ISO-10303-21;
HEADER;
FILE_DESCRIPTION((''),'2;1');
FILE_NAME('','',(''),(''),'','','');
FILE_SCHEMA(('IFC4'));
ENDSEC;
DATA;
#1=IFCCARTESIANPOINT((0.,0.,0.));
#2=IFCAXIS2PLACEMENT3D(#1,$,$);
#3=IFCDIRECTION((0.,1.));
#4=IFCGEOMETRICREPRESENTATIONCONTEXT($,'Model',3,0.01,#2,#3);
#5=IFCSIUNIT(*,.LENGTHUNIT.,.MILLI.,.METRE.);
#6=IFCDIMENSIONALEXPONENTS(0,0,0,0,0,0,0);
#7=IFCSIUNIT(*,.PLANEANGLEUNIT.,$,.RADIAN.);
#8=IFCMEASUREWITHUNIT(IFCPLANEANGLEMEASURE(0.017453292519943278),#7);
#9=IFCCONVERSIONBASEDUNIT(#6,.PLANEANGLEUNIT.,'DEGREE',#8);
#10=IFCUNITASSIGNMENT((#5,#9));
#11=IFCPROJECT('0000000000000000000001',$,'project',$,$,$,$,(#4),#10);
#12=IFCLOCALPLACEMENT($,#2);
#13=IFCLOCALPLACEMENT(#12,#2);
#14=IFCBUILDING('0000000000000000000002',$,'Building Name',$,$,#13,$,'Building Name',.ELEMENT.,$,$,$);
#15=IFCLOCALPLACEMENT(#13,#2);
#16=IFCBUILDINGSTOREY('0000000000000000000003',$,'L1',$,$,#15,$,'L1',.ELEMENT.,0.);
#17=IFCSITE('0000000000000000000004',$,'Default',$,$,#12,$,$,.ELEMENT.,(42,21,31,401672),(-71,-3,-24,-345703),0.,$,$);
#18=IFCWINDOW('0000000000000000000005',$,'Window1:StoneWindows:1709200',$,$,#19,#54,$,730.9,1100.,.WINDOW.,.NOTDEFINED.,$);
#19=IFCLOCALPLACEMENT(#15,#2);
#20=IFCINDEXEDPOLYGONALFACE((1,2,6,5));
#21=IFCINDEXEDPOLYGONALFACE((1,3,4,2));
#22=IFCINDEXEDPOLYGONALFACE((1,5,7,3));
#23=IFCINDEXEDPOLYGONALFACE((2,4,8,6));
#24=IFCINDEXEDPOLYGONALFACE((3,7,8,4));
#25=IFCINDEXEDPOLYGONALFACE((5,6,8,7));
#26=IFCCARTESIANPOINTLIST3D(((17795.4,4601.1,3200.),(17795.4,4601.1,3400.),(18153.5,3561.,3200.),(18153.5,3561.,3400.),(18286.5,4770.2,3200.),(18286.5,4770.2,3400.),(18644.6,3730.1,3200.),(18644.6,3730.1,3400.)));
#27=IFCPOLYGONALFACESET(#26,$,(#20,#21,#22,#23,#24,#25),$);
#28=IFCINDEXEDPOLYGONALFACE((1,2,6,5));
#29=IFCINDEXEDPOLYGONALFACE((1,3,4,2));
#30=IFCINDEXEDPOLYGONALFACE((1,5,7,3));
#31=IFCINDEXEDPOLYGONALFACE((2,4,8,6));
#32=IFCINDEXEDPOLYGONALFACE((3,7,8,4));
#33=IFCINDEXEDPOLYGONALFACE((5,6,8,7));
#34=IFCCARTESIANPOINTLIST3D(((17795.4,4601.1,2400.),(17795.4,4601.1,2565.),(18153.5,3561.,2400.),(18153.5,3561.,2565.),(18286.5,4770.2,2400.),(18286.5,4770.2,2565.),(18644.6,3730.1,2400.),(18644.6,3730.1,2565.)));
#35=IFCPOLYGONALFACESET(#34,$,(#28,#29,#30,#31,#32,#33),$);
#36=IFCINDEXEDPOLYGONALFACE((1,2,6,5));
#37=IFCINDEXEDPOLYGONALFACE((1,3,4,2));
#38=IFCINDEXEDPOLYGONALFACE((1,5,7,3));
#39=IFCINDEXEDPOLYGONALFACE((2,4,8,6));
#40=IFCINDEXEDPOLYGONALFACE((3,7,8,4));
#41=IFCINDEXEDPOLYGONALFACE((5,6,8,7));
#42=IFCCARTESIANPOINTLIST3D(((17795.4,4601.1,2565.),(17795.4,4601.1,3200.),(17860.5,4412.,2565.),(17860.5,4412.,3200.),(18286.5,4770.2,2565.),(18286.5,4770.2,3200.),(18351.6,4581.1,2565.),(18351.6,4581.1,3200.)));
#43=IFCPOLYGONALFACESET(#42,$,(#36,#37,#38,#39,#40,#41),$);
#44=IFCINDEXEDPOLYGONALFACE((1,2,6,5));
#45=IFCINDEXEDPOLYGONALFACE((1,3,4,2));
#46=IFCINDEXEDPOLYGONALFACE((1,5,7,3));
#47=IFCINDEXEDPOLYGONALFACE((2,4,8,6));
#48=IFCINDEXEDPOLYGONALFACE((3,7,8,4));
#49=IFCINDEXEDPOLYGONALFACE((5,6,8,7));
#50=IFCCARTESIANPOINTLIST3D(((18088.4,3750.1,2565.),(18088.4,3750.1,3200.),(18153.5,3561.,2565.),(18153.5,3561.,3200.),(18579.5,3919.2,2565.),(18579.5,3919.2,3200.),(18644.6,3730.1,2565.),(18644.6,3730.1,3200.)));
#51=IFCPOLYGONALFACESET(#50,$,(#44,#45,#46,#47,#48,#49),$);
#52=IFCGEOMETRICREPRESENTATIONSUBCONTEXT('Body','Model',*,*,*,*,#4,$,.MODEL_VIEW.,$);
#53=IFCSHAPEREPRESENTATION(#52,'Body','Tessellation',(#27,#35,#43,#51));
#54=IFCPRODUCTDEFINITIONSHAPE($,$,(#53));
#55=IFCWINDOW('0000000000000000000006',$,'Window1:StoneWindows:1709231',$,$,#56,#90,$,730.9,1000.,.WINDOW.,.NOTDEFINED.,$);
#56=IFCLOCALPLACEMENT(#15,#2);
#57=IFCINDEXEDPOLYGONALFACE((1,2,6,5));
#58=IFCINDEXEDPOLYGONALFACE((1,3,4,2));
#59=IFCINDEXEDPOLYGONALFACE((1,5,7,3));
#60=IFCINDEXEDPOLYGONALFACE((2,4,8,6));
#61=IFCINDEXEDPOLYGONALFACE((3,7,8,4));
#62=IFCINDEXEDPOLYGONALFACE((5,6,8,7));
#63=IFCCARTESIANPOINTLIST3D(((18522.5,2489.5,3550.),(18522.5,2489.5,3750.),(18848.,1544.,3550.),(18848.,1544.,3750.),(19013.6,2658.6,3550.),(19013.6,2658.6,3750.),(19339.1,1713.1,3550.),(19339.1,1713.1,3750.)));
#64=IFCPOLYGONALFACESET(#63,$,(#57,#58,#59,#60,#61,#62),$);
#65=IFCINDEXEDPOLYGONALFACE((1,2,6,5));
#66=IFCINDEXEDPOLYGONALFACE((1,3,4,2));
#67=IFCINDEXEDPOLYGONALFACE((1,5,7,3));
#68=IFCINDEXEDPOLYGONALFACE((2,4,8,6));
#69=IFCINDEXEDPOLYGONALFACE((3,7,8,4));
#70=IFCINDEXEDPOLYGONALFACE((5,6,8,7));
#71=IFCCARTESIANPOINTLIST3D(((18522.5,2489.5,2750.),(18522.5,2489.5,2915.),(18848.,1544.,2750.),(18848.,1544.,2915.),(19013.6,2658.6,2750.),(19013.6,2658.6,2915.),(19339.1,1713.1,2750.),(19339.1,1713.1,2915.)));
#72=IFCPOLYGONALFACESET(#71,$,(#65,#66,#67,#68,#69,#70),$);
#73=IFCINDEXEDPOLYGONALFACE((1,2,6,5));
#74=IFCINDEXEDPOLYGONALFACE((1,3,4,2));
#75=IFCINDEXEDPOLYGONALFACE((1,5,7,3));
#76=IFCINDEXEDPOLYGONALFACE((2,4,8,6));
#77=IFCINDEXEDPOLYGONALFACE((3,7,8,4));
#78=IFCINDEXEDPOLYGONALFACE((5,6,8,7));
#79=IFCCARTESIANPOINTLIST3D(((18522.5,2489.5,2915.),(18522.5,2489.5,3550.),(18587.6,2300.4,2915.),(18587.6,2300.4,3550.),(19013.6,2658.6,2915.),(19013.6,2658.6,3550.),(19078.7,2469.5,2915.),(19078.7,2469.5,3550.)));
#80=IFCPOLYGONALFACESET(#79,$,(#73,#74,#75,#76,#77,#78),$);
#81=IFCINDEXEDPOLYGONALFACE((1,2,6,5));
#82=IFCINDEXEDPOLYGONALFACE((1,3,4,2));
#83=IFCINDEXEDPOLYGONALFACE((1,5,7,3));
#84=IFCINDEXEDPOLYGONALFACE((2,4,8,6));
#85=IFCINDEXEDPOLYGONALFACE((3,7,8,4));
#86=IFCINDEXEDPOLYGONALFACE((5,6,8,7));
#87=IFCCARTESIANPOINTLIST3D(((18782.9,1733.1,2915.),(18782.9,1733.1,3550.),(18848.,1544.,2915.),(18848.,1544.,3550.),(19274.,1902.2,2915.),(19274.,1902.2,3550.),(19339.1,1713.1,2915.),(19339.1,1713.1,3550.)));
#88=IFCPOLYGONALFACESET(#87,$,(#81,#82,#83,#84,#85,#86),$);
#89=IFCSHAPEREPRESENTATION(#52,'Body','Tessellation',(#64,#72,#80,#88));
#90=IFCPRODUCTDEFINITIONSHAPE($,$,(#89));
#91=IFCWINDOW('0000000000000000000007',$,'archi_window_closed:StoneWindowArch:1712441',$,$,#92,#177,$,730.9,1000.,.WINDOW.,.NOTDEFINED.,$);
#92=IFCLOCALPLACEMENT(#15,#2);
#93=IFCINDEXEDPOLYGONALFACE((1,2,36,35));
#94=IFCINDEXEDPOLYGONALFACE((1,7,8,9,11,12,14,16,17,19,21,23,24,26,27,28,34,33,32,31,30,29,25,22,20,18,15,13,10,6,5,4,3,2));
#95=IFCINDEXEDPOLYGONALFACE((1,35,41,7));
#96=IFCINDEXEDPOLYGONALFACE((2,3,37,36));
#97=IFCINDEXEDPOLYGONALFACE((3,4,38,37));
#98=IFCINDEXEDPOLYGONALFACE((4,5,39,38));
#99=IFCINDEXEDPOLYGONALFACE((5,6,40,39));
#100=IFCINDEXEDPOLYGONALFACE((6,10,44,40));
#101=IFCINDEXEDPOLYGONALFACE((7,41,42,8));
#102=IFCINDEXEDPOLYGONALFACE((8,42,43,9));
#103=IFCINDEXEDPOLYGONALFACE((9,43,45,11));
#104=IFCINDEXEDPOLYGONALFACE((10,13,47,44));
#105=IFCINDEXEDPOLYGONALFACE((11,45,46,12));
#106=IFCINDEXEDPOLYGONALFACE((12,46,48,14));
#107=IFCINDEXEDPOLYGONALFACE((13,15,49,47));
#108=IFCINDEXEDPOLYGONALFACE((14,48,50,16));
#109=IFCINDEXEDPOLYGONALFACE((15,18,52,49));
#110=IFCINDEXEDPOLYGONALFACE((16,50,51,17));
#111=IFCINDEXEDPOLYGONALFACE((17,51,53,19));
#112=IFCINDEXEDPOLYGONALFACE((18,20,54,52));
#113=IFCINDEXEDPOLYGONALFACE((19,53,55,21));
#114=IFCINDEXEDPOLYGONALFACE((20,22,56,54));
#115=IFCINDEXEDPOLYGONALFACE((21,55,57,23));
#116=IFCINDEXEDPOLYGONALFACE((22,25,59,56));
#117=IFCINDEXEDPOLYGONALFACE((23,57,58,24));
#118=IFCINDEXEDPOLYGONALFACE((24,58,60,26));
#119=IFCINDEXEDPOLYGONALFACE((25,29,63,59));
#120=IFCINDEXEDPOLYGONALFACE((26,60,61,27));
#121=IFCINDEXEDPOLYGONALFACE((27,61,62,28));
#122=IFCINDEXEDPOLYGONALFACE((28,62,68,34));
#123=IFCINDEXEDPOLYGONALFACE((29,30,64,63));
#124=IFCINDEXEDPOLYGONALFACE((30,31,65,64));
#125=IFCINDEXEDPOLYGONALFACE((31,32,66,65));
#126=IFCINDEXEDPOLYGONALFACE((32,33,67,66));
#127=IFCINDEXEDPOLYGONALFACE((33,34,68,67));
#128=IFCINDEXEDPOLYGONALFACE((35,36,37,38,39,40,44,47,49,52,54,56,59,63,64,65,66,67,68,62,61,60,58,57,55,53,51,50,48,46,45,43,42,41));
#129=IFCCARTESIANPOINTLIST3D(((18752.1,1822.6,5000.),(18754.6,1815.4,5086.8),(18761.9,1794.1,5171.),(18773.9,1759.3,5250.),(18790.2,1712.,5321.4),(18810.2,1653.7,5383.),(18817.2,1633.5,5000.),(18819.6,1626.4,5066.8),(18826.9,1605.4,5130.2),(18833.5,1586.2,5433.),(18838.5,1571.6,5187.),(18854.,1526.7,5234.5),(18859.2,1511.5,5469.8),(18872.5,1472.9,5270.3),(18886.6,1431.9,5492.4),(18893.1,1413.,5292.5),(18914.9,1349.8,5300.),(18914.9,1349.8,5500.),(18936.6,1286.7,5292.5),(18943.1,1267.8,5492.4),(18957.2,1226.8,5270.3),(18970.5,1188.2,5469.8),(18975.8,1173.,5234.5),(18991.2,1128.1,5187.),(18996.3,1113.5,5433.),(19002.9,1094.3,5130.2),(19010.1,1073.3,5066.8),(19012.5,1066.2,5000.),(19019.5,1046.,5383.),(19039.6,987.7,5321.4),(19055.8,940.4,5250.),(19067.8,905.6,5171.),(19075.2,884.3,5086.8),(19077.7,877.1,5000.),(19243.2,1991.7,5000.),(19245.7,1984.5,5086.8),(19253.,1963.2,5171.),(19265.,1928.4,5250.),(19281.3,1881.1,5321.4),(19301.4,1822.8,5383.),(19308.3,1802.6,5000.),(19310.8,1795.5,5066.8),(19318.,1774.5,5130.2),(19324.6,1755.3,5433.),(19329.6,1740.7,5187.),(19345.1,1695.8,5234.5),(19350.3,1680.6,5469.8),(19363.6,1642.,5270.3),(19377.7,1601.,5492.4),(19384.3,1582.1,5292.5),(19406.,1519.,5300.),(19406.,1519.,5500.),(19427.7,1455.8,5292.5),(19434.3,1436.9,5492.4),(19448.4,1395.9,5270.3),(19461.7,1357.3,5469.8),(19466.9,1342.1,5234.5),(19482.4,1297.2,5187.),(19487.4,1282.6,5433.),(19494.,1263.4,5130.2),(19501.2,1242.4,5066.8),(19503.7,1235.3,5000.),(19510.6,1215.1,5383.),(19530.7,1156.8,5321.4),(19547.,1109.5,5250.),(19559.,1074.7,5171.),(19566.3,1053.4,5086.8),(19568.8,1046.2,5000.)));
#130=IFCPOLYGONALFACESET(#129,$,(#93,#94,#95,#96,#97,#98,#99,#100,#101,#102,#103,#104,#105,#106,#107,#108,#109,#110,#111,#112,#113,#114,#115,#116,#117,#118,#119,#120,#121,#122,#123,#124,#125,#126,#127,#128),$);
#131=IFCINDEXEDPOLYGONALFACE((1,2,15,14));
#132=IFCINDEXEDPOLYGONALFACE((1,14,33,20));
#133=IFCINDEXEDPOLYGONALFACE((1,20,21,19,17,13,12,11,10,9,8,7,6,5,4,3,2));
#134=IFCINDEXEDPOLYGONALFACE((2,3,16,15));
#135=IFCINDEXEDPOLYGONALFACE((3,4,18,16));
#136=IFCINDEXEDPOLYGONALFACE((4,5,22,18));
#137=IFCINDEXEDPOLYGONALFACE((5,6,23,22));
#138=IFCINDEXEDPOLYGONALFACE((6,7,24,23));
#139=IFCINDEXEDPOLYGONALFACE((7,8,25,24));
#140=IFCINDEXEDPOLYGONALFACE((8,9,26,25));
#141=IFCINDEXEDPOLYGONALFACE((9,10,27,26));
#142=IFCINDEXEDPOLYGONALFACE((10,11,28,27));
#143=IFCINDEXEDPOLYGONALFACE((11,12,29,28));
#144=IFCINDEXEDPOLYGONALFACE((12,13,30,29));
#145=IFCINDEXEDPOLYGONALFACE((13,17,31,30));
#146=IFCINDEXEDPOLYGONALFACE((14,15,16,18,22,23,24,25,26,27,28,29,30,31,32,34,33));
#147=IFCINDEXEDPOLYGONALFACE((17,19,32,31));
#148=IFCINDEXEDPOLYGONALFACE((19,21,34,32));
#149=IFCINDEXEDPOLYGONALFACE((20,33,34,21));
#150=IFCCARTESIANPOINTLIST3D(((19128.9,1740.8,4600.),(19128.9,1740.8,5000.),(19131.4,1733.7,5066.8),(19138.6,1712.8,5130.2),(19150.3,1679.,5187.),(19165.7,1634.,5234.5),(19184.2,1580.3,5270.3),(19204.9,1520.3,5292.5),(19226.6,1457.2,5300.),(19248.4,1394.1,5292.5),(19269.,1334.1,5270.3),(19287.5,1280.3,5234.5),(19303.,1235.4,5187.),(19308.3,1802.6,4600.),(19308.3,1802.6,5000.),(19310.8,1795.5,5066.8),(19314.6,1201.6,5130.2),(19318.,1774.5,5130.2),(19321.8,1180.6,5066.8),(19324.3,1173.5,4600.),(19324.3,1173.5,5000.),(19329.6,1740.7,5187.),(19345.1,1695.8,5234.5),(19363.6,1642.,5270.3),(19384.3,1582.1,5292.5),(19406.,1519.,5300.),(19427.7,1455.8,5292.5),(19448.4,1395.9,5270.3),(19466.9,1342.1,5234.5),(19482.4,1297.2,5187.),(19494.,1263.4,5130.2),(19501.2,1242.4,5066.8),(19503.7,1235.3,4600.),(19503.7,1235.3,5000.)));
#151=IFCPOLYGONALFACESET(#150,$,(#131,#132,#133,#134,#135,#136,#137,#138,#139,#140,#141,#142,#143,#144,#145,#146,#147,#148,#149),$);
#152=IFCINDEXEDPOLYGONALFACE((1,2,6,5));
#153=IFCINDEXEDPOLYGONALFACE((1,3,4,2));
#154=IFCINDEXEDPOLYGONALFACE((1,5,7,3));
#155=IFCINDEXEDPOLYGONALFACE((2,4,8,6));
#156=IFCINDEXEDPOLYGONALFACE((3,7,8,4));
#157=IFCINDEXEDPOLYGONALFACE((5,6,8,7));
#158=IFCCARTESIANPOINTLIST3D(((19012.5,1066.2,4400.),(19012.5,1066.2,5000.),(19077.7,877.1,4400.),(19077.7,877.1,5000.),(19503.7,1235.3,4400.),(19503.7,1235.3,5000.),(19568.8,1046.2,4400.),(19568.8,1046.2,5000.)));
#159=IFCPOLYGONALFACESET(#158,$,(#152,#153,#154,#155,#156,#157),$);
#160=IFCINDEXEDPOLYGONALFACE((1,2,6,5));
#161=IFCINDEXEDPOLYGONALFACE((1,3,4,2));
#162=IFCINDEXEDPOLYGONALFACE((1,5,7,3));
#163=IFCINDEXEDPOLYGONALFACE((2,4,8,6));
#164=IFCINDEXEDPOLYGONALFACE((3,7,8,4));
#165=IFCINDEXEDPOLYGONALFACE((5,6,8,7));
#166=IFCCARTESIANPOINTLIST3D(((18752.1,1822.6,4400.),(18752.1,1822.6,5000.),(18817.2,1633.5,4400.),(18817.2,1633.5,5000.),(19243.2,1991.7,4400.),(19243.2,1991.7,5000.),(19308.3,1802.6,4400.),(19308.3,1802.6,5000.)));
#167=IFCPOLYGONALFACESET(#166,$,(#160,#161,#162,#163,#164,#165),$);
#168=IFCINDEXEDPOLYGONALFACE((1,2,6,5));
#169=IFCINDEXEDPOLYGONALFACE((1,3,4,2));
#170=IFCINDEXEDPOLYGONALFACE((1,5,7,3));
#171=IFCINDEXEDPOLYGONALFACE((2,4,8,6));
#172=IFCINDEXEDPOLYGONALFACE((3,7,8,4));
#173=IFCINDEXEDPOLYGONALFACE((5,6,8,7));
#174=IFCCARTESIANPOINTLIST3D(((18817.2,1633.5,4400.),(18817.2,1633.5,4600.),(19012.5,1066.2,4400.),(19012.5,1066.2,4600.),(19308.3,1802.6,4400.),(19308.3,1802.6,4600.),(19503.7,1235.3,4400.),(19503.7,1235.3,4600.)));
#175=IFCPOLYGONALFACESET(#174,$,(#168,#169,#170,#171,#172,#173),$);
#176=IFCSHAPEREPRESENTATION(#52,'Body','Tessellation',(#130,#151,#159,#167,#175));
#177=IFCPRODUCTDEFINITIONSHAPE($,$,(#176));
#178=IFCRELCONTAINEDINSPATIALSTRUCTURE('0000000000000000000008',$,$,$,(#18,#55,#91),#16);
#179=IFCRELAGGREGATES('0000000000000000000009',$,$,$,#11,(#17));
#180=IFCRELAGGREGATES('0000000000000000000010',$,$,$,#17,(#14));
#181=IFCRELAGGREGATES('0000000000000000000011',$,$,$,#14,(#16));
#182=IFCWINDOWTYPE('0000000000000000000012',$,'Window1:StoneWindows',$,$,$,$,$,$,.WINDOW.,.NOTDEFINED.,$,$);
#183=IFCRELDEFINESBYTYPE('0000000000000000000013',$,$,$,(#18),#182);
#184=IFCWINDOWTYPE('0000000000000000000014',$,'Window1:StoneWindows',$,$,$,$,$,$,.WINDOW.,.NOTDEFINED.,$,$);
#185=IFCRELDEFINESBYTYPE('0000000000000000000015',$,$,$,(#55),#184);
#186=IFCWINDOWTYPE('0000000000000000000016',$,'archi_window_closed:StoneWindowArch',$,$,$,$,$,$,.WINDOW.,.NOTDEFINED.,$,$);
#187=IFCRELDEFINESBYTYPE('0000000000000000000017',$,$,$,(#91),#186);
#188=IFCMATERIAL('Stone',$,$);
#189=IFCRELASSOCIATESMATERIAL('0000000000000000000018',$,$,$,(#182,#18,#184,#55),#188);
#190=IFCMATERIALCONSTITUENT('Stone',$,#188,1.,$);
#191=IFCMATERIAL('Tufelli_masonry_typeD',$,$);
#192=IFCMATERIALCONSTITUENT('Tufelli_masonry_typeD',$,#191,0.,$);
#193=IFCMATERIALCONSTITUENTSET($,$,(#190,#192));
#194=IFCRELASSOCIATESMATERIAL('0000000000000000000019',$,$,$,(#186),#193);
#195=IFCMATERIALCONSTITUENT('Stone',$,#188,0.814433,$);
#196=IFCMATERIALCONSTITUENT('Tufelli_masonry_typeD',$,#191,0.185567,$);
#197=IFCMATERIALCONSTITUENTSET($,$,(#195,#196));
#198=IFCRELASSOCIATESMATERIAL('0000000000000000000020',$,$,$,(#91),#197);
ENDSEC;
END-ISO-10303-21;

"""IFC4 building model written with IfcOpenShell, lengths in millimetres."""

from ifc_helpers import new_model, entity, si_unit, converted_unit, direction, frame, origin, place, context, subcontext, project, spatial, line, arc, indexed_curve, outline, extrude, source, transform, mapped, material, constituent, constituent_set, type_object, type_shapes, element, save


model = new_model("IFC4")

# Units and contexts
model_context = context("Model", 3, precision=0.01, world=origin(), true_north=direction((0.0, 1.0)))
body_context = subcontext(model_context, "Body", "Model", "MODEL_VIEW")
ifc_project = project(units=[si_unit("LENGTHUNIT", "METRE", prefix="MILLI"), converted_unit("PLANEANGLEUNIT", "DEGREE", entity("IfcPlaneAngleMeasure", 0.017453292519943278), si_unit("PLANEANGLEUNIT", "RADIAN"), dimensions=[0, 0, 0, 0, 0, 0, 0])], contexts=[model_context])

# Site, building, storey
site_placement = place(None, origin())
site = spatial("IfcSite", under=ifc_project, at=site_placement, Name="Default", CompositionType="ELEMENT", RefLatitude=(42, 21, 31, 401672), RefLongitude=(-71, -3, -24, -345703), RefElevation=0.0)
building_placement = place(site_placement, origin())
building = spatial("IfcBuilding", under=site, at=building_placement, Name="Building Name", LongName="Building Name", CompositionType="ELEMENT")
storey_placement = place(building_placement, origin())
storey = spatial("IfcBuildingStorey", under=building, at=storey_placement, Name="L1", LongName="L1", CompositionType="ELEMENT", Elevation=0.0)

# Shared definitions
ifc_material_1 = material(Name="Tufelli_masonry_typeD")

# Shared definitions
ifc_material_2 = material(Name="Stone")

# Windows
window_type_1 = type_object("IfcWindowType", Name="Window1:StoneWindows", PartitioningType="NOTDEFINED", PredefinedType="WINDOW", material=ifc_material_2)
shared_shape_1 = source(origin(), body_context, "Body", "SweptSolid", [
    extrude(outline(indexed_curve([(-259.7, -550.0), (259.7, -550.0), (259.7, 550.0), (-259.7, 550.0), (-259.7, -550.0)], self_intersect=False)), frame((0.0, 0.0, 1600.0), z_axis=(0.0, 0.0, 1.0), x_axis=(0.0, 1.0, 0.0)), (0.0, 0.0, 1.0), 200.0),
    extrude(outline(indexed_curve([(-259.7, -550.0), (259.7, -550.0), (259.7, 550.0), (-259.7, 550.0), (-259.7, -550.0)], self_intersect=False)), frame((0.0, 0.0, 800.0), z_axis=(0.0, 0.0, 1.0), x_axis=(0.0, 1.0, 0.0)), (0.0, 0.0, 1.0), 165.0),
    extrude(outline(indexed_curve([(-259.7, -100.0), (259.7, -100.0), (259.7, 100.0), (-259.7, 100.0), (-259.7, -100.0)], self_intersect=False)), frame((-450.0, 0.0, 965.0), z_axis=(0.0, 0.0, 1.0), x_axis=(0.0, 1.0, 0.0)), (0.0, 0.0, 1.0), 635.0),
    extrude(outline(indexed_curve([(-259.7, -100.0), (259.7, -100.0), (259.7, 100.0), (-259.7, 100.0), (-259.7, -100.0)], self_intersect=False)), frame((450.0, 0.0, 965.0), z_axis=(0.0, 0.0, 1.0), x_axis=(0.0, 1.0, 0.0)), (0.0, 0.0, 1.0), 635.0),
])
type_shapes(window_type_1, [shared_shape_1])
window_1_placement = place(storey_placement, frame((18220.0, 4165.6, 1600.0), z_axis=(0.0, 0.0, 1.0), x_axis=(0.325568, -0.945519, 0.0)))
element("IfcWindow", 1, at=window_1_placement, inside=storey, type_object=window_type_1, material=ifc_material_2, Name="Window1:StoneWindows:1709200", OverallHeight=730.9, OverallWidth=1100.0, PartitioningType="NOTDEFINED", PredefinedType="WINDOW", context=body_context, shape_type="MappedRepresentation", body=[
    mapped(shared_shape_1, transform((0.0, 0.0, 0.0), scale=1.0)),
])
window_type_2 = type_object("IfcWindowType", Name="Window1:StoneWindows", PartitioningType="NOTDEFINED", PredefinedType="WINDOW", material=ifc_material_2)
shared_shape_2 = source(origin(), body_context, "Body", "SweptSolid", [
    extrude(outline(indexed_curve([(-259.7, -500.0), (259.7, -500.0), (259.7, 500.0), (-259.7, 500.0), (-259.7, -500.0)], self_intersect=False)), frame((0.0, 0.0, 1600.0), z_axis=(0.0, 0.0, 1.0), x_axis=(0.0, 1.0, 0.0)), (0.0, 0.0, 1.0), 200.0),
    extrude(outline(indexed_curve([(-259.7, -500.0), (259.7, -500.0), (259.7, 500.0), (-259.7, 500.0), (-259.7, -500.0)], self_intersect=False)), frame((0.0, 0.0, 800.0), z_axis=(0.0, 0.0, 1.0), x_axis=(0.0, 1.0, 0.0)), (0.0, 0.0, 1.0), 165.0),
    extrude(outline(indexed_curve([(-259.7, -100.0), (259.7, -100.0), (259.7, 100.0), (-259.7, 100.0), (-259.7, -100.0)], self_intersect=False)), frame((-400.0, 0.0, 965.0), z_axis=(0.0, 0.0, 1.0), x_axis=(0.0, 1.0, 0.0)), (0.0, 0.0, 1.0), 635.0),
    extrude(outline(indexed_curve([(-259.7, -100.0), (259.7, -100.0), (259.7, 100.0), (-259.7, 100.0), (-259.7, -100.0)], self_intersect=False)), frame((400.0, 0.0, 965.0), z_axis=(0.0, 0.0, 1.0), x_axis=(0.0, 1.0, 0.0)), (0.0, 0.0, 1.0), 635.0),
])
type_shapes(window_type_2, [shared_shape_2])
window_2_placement = place(storey_placement, frame((18930.8, 2101.3, 1950.0), z_axis=(0.0, 0.0, 1.0), x_axis=(0.325568, -0.945519, 0.0)))
element("IfcWindow", 2, at=window_2_placement, inside=storey, type_object=window_type_2, material=ifc_material_2, Name="Window1:StoneWindows:1709231", OverallHeight=730.9, OverallWidth=1000.0, PartitioningType="NOTDEFINED", PredefinedType="WINDOW", context=body_context, shape_type="MappedRepresentation", body=[
    mapped(shared_shape_2, transform((0.0, 0.0, 0.0), scale=1.0)),
])
ifc_constituent_1 = constituent(ifc_material_2, Name="Stone", fraction=0.814433)
ifc_constituent_2 = constituent(ifc_material_1, Name="Tufelli_masonry_typeD", fraction=0.185567)
ifc_constituent_set_1 = constituent_set(constituents=[ifc_constituent_1, ifc_constituent_2])
ifc_constituent_3 = constituent(ifc_material_2, Name="Stone", fraction=1.0)
ifc_constituent_4 = constituent(ifc_material_1, Name="Tufelli_masonry_typeD", fraction=0.0)
ifc_constituent_set_2 = constituent_set(constituents=[ifc_constituent_3, ifc_constituent_4])
window_type_3 = type_object("IfcWindowType", Name="archi_window_closed:StoneWindowArch", PartitioningType="NOTDEFINED", PredefinedType="WINDOW", material=ifc_constituent_set_2)
shared_shape_3 = source(origin(), body_context, "Body", "SweptSolid", [
    extrude(outline(indexed_curve([(300.0, 0.0), (500.0, 0.0), (0.0, 500.0), (-500.0, 0.0), (-300.0, 0.0), (0.0, 300.0)], segments=[line(1, 2), arc(2, 3, 4), line(4, 5), arc(5, 6, 1)], self_intersect=False)), frame((0.0, -259.7, 1400.0), z_axis=(0.0, -1.0, 0.0), x_axis=(1.0, 0.0, 0.0)), (0.0, 0.0, -1.0), 519.4),
    extrude(outline(indexed_curve([(-200.0, -300.0), (200.0, -300.0), (200.0, 300.0), (-200.0, 300.0), (-500.0, 0.0)], segments=[line(1, 2, 3, 4), arc(4, 5, 1)], self_intersect=False)), frame((0.0, 70.0, 1200.0), z_axis=(0.0, 1.0, 0.0), x_axis=(0.0, 0.0, -1.0)), (0.0, 0.0, 1.0), 189.7),
    extrude(outline(indexed_curve([(-259.7, -100.0), (259.7, -100.0), (259.7, 100.0), (-259.7, 100.0), (-259.7, -100.0)], self_intersect=False)), frame((400.0, 0.0, 800.0), z_axis=(0.0, 0.0, 1.0), x_axis=(0.0, 1.0, 0.0)), (0.0, 0.0, 1.0), 600.0),
    extrude(outline(indexed_curve([(-259.7, -100.0), (259.7, -100.0), (259.7, 100.0), (-259.7, 100.0), (-259.7, -100.0)], self_intersect=False)), frame((-400.0, 0.0, 800.0), z_axis=(0.0, 0.0, 1.0), x_axis=(0.0, 1.0, 0.0)), (0.0, 0.0, 1.0), 600.0),
    extrude(outline(indexed_curve([(-259.7, -300.0), (259.7, -300.0), (259.7, 300.0), (-259.7, 300.0), (-259.7, -300.0)], self_intersect=False)), frame((0.0, 0.0, 800.0), z_axis=(0.0, 0.0, 1.0), x_axis=(0.0, 1.0, 0.0)), (0.0, 0.0, 1.0), 200.0),
])
type_shapes(window_type_3, [shared_shape_3])
window_3_placement = place(storey_placement, frame((19160.4, 1434.4, 3600.0), z_axis=(0.0, 0.0, 1.0), x_axis=(0.325568, -0.945519, 0.0)))
element("IfcWindow", 3, at=window_3_placement, inside=storey, type_object=window_type_3, material=ifc_constituent_set_1, Name="archi_window_closed:StoneWindowArch:1712441", OverallHeight=730.9, OverallWidth=1000.0, PartitioningType="NOTDEFINED", PredefinedType="WINDOW", context=body_context, shape_type="MappedRepresentation", body=[
    mapped(shared_shape_3, transform((0.0, 0.0, 0.0), scale=1.0)),
])

save(model, "model.ifc")
